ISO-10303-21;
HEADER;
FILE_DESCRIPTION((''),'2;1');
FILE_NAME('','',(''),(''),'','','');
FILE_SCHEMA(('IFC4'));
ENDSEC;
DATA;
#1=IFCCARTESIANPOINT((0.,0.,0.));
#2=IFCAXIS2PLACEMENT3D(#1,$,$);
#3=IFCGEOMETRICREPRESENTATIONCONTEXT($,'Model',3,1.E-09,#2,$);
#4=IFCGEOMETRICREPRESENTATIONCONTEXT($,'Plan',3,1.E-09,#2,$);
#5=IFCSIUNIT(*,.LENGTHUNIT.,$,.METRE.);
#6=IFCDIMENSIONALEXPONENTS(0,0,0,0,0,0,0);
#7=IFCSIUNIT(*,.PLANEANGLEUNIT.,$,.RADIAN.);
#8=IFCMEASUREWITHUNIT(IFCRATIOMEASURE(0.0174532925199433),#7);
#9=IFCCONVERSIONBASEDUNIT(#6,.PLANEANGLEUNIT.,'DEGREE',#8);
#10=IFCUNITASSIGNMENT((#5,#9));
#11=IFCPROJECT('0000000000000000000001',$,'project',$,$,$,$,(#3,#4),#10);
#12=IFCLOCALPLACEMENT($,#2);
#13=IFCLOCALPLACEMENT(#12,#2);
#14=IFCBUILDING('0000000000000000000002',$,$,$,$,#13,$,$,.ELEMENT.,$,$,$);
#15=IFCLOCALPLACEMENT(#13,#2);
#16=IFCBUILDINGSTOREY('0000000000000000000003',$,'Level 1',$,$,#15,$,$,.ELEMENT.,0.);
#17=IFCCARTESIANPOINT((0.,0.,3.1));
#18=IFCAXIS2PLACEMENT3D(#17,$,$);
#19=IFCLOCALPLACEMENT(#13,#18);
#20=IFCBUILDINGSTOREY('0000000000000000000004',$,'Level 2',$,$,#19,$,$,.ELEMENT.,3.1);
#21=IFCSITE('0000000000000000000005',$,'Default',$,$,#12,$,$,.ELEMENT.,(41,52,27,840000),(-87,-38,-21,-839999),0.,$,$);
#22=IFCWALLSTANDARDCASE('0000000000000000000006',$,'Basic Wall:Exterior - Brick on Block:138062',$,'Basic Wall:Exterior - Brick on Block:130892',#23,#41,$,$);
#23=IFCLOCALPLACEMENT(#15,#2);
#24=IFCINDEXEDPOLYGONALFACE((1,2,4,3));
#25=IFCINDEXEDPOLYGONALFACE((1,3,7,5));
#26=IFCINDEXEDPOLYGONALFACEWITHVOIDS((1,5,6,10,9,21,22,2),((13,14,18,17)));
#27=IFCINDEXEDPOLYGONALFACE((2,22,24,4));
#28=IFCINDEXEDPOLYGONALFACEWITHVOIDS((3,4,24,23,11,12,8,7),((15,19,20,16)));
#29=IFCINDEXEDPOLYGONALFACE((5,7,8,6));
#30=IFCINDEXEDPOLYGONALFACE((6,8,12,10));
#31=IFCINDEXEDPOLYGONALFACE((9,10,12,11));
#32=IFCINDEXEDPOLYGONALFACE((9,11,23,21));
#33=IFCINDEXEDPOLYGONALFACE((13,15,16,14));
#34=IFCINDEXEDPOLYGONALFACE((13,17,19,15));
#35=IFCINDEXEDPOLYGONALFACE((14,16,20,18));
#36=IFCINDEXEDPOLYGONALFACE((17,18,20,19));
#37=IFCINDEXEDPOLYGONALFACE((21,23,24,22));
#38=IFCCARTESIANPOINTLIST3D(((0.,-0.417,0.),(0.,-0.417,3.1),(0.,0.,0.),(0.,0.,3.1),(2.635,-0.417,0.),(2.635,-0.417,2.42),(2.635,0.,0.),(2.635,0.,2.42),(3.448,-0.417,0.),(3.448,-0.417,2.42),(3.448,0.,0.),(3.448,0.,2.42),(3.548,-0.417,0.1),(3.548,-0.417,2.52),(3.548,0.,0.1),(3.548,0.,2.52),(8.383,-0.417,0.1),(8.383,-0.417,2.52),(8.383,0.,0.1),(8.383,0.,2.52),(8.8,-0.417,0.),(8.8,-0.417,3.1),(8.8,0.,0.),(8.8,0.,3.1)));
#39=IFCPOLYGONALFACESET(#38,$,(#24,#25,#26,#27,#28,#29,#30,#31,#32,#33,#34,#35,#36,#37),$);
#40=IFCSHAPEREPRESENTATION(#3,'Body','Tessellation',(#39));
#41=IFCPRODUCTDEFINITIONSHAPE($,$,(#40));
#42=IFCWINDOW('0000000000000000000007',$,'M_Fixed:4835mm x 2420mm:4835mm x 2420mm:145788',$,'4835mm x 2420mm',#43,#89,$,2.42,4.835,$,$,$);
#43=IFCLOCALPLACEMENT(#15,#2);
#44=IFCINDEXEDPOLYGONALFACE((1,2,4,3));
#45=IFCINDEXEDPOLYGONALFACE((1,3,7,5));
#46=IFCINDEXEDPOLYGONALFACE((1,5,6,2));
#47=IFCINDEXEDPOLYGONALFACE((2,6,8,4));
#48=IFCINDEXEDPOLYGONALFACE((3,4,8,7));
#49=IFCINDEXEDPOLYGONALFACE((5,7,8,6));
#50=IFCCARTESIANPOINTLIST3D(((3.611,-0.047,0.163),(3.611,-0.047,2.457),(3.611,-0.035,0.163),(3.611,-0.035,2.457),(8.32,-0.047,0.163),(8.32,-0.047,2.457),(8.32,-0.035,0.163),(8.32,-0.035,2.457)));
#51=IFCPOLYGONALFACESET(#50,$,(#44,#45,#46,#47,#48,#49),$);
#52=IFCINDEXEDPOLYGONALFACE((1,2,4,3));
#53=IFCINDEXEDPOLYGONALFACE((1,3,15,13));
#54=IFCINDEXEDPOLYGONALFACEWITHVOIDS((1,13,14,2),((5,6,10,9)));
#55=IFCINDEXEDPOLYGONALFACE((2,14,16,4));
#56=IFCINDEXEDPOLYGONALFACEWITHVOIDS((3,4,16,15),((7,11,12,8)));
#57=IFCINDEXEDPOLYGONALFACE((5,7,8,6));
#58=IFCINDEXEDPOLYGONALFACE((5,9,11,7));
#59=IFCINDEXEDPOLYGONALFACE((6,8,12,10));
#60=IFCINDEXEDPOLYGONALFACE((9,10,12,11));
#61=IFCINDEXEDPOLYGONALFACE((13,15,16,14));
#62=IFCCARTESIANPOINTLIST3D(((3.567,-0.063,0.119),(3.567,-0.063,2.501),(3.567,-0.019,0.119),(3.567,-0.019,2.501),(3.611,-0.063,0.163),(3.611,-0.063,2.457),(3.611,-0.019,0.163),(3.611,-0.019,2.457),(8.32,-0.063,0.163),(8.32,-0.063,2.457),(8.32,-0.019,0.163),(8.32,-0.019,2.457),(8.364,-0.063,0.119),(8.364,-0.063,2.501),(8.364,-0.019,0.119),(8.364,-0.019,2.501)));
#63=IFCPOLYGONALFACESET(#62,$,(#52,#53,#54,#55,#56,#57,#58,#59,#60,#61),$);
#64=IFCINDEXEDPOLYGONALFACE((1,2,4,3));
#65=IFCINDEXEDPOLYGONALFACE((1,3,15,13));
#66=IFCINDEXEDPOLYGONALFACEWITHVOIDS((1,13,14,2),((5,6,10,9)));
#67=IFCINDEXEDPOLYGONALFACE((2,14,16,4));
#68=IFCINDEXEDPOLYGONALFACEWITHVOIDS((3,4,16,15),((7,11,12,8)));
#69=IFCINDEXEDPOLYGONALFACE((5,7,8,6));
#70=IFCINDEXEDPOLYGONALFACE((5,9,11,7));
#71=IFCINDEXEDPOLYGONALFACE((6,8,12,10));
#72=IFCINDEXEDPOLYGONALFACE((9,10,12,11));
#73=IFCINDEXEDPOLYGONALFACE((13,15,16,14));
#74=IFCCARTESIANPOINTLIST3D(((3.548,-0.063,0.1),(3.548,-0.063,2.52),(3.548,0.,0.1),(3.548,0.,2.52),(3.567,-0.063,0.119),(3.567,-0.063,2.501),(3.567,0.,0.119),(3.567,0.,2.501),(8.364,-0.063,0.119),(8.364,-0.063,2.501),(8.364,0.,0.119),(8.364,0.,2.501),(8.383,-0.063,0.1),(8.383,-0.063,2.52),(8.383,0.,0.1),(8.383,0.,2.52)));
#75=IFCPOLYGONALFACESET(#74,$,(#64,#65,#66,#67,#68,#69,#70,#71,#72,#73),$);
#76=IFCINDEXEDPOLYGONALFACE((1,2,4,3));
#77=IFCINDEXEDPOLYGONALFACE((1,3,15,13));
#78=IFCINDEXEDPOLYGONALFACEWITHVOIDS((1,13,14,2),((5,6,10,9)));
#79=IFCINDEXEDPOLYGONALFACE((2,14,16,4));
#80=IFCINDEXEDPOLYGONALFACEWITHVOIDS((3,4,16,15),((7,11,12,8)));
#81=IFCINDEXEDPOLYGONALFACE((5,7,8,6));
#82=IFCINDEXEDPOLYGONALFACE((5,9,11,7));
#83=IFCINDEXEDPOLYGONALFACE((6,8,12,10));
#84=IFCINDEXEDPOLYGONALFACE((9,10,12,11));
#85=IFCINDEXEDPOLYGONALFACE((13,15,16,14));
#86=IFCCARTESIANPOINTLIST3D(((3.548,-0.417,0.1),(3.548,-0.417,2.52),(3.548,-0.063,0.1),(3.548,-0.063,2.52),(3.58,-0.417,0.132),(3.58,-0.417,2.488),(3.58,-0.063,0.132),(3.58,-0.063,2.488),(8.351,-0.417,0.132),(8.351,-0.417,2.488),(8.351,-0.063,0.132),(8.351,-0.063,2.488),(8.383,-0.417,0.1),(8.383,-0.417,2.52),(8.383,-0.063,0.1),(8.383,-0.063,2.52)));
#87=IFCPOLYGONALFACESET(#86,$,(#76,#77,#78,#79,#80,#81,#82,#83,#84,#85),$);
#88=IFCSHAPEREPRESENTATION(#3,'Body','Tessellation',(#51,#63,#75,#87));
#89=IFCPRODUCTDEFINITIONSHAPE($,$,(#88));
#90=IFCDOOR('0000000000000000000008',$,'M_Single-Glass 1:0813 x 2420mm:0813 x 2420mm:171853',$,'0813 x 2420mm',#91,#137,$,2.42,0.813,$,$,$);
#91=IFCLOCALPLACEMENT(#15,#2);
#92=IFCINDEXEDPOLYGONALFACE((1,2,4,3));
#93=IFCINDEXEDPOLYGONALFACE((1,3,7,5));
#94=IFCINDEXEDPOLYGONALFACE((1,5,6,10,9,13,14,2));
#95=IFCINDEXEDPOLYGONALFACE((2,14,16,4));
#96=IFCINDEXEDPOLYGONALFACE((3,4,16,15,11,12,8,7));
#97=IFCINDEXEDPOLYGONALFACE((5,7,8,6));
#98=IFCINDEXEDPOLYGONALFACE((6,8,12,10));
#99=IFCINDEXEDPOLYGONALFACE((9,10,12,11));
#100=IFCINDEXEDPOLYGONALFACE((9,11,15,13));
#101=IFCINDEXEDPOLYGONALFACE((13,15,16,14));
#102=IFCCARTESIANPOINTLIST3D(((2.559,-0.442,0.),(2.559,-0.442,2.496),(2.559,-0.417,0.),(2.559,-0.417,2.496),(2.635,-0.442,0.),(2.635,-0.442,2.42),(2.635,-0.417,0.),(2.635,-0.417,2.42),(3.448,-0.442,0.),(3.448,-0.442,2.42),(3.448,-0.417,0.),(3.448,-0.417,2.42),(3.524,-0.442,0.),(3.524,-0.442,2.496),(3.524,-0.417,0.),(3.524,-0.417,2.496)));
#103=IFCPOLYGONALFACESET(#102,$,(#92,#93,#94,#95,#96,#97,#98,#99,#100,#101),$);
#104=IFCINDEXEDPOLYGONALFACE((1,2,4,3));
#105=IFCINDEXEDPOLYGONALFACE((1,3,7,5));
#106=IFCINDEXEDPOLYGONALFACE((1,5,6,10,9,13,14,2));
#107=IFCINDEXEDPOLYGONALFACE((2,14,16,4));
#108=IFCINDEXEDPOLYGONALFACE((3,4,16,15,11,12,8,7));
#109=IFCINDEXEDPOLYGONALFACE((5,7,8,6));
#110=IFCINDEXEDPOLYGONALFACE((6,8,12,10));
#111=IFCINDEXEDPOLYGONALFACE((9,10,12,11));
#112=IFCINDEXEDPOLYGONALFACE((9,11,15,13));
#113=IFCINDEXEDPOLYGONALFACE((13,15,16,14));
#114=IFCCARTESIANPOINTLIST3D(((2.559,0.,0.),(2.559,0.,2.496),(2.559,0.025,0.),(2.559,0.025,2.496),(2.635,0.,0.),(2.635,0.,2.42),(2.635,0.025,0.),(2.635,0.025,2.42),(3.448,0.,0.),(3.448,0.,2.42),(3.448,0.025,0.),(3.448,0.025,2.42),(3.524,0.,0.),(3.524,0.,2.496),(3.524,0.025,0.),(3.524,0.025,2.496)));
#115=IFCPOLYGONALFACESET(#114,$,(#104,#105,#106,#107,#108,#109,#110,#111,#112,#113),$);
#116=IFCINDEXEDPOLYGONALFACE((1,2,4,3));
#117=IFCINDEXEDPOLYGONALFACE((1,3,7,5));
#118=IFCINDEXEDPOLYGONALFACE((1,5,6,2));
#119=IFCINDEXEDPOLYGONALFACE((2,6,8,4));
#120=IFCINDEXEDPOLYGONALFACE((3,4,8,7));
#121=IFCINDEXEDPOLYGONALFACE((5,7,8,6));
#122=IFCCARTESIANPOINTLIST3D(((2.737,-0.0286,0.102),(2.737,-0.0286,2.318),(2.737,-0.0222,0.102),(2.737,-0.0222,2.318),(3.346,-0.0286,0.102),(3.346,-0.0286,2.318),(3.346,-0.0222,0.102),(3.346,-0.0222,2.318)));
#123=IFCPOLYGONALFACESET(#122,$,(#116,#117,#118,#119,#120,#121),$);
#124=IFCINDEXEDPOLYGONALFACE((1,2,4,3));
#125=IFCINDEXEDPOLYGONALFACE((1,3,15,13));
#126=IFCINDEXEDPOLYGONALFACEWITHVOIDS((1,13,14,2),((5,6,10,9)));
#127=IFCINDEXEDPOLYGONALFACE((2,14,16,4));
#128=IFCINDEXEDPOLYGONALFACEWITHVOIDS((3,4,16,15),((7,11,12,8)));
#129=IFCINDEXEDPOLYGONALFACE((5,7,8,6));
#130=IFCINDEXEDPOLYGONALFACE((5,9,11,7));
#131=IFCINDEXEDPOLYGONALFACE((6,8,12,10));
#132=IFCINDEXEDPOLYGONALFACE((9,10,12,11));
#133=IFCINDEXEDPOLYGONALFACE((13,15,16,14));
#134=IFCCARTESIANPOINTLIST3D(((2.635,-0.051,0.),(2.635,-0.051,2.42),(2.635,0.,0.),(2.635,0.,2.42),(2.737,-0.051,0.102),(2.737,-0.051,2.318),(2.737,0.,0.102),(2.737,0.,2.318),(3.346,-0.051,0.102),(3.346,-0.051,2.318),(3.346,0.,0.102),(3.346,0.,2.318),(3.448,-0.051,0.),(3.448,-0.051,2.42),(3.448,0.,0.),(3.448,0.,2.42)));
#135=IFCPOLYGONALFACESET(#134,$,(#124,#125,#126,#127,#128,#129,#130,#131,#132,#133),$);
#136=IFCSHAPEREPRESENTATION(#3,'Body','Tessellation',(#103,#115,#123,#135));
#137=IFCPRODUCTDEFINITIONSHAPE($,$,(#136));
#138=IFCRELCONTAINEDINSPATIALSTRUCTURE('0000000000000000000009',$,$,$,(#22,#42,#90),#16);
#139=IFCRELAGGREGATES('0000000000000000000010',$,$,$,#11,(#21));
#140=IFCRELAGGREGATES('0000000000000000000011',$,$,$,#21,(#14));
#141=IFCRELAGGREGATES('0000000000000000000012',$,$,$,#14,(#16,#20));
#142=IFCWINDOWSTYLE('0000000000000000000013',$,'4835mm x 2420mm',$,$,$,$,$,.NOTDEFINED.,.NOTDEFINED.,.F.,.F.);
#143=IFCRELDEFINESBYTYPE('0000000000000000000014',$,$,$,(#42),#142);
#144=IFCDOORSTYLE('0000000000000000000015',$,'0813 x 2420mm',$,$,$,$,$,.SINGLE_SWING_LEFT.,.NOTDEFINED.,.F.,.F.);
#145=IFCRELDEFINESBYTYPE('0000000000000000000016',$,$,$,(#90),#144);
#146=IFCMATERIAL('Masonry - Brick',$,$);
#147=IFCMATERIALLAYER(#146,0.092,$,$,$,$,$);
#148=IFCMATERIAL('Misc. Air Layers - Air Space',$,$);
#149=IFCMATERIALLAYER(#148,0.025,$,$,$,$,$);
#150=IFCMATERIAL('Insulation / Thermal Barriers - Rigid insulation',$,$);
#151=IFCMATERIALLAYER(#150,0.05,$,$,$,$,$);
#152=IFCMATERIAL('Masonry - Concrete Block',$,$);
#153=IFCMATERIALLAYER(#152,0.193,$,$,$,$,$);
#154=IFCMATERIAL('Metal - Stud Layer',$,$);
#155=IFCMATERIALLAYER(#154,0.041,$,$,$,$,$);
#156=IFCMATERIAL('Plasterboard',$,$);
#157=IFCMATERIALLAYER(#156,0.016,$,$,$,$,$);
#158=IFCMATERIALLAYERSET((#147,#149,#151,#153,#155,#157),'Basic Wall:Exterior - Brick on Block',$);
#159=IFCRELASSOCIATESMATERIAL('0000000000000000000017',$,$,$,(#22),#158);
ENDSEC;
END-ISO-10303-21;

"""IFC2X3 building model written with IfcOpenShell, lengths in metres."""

from ifc_helpers import new_model, entity, si_unit, converted_unit, frame, frame_2d, origin, origin_2d_with_axis, place, context, project, spatial, polyline, rectangle, outline, extrude, source, transform, mapped, material, layer, layer_set, layer_usage, type_object, type_shapes, element, fill, save


model = new_model("IFC2X3")

# Units and contexts
model_context = context("Model", 3, precision=1e-09, world=origin())
plan_context = context("Plan", 3, precision=1e-09, world=origin())
ifc_project = project(units=[si_unit("LENGTHUNIT", "METRE"), converted_unit("PLANEANGLEUNIT", "DEGREE", entity("IfcRatioMeasure", 0.0174532925199433), si_unit("PLANEANGLEUNIT", "RADIAN"), dimensions=[0, 0, 0, 0, 0, 0, 0])], contexts=[model_context, plan_context])

# Site, building, storey
site_placement = place(None, origin())
site = spatial("IfcSite", under=ifc_project, at=site_placement, Name="Default", CompositionType="ELEMENT", RefLatitude=(41, 52, 27, 840000), RefLongitude=(-87, -38, -21, -839999), RefElevation=0.0)
building_placement = place(site_placement, origin())
building = spatial("IfcBuilding", under=site, at=building_placement, CompositionType="ELEMENT")
storey_1_placement = place(building_placement, origin())
storey_1 = spatial("IfcBuildingStorey", under=building, at=storey_1_placement, Name="Level 1", CompositionType="ELEMENT", Elevation=0.0)

# Wall, openings, window, door
ifc_material_1 = material(Name="Masonry - Brick")
ifc_layer_1 = layer(ifc_material_1, 0.092)
ifc_material_2 = material(Name="Misc. Air Layers - Air Space")
ifc_layer_2 = layer(ifc_material_2, 0.025)
ifc_material_3 = material(Name="Insulation / Thermal Barriers - Rigid insulation")
ifc_layer_3 = layer(ifc_material_3, 0.05)
ifc_material_4 = material(Name="Masonry - Concrete Block")
ifc_layer_4 = layer(ifc_material_4, 0.193)
ifc_material_5 = material(Name="Metal - Stud Layer")
ifc_layer_5 = layer(ifc_material_5, 0.041)
ifc_material_6 = material(Name="Plasterboard")
ifc_layer_6 = layer(ifc_material_6, 0.016)
ifc_layer_set_1 = layer_set([ifc_layer_1, ifc_layer_2, ifc_layer_3, ifc_layer_4, ifc_layer_5, ifc_layer_6], Name="Basic Wall:Exterior - Brick on Block")
ifc_layer_usage_1 = layer_usage(ifc_layer_set_1, "AXIS2", "NEGATIVE", 0.2085)
wall_1_placement = place(storey_1_placement, frame((0.0, -0.2085, 0.0)))
wall_1 = element("IfcWallStandardCase", 1, at=wall_1_placement, inside=storey_1, material=ifc_layer_usage_1, Name="Basic Wall:Exterior - Brick on Block:138062", ObjectType="Basic Wall:Exterior - Brick on Block:130892", context=model_context, shape_type="SweptSolid", body=[
    extrude(rectangle(XDim=8.8, YDim=0.417, at=frame_2d((4.4, 0.0), x_axis=(-1.0, 0.0))), origin(), (0.0, 0.0, 1.0), 3.1),
])
opening_1_placement = place(wall_1_placement, frame((3.548, -0.2085, 0.1)))
opening_1 = element("IfcOpeningElement", 2, at=opening_1_placement, cuts=wall_1, ObjectType="Opening", context=model_context, shape_type="SweptSolid", body=[
    extrude(rectangle(XDim=2.42, YDim=4.835, at=frame_2d((1.21, 2.4175), x_axis=(1.0, 0.0))), frame((0.0, 0.0, 0.0), z_axis=(0.0, 1.0, 0.0), x_axis=(0.0, 0.0, 1.0)), (0.0, 0.0, 1.0), 0.417),
])
opening_2_placement = place(wall_1_placement, frame((2.635, -0.2085, 0.0)))
opening_2 = element("IfcOpeningElement", 3, at=opening_2_placement, cuts=wall_1, ObjectType="Opening", context=model_context, shape_type="SweptSolid", body=[
    extrude(rectangle(XDim=0.813, YDim=2.42, at=frame_2d((1.21, 0.4065), x_axis=(0.0, -1.0))), frame((0.0, 0.0, 0.0), z_axis=(0.0, 1.0, 0.0), x_axis=(0.0, 0.0, 1.0)), (0.0, 0.0, 1.0), 0.417),
])
window_style_1 = type_object("IfcWindowStyle", Name="4835mm x 2420mm", ConstructionType="NOTDEFINED", OperationType="NOTDEFINED", ParameterTakesPrecedence=False, Sizeable=False)
shared_shape_1 = source(origin(), model_context, "Body", "SweptSolid", [
    extrude(rectangle(XDim=0.012, YDim=4.709, at=origin_2d_with_axis()), frame((2.4175, 0.376, 0.063), z_axis=(0.0, 0.0, 1.0), x_axis=(0.0, -1.0, 0.0)), (0.0, 0.0, 1.0), 2.294),
    extrude(outline(polyline([(-2.3985, -1.191), (2.3985, -1.191), (2.3985, 1.191), (-2.3985, 1.191), (-2.3985, -1.191)]), holes=[polyline([(-2.3545, -1.147), (-2.3545, 1.147), (2.3545, 1.147), (2.3545, -1.147), (-2.3545, -1.147)])]), frame((2.4175, 0.354, 1.21), z_axis=(0.0, 1.0, 0.0), x_axis=(1.0, 0.0, 0.0)), (0.0, 0.0, 1.0), 0.044),
    extrude(outline(polyline([(-2.4175, -1.21), (2.4175, -1.21), (2.4175, 1.21), (-2.4175, 1.21), (-2.4175, -1.21)]), holes=[polyline([(-2.3985, -1.191), (-2.3985, 1.191), (2.3985, 1.191), (2.3985, -1.191), (-2.3985, -1.191)])]), frame((2.4175, 0.354, 1.21), z_axis=(0.0, 1.0, 0.0), x_axis=(1.0, 0.0, 0.0)), (0.0, 0.0, 1.0), 0.063),
    extrude(outline(polyline([(-2.4175, -1.21), (2.4175, -1.21), (2.4175, 1.21), (-2.4175, 1.21), (-2.4175, -1.21)]), holes=[polyline([(-2.3855, -1.178), (-2.3855, 1.178), (2.3855, 1.178), (2.3855, -1.178), (-2.3855, -1.178)])]), frame((2.4175, 0.0, 1.21), z_axis=(0.0, 1.0, 0.0), x_axis=(1.0, 0.0, 0.0)), (0.0, 0.0, 1.0), 0.354),
])
type_shapes(window_style_1, [shared_shape_1])
window_1_placement = place(opening_1_placement, origin())
window_1 = element("IfcWindow", 4, at=window_1_placement, inside=storey_1, type_object=window_style_1, Name="M_Fixed:4835mm x 2420mm:4835mm x 2420mm:145788", ObjectType="4835mm x 2420mm", OverallHeight=2.42, OverallWidth=4.835, context=model_context, shape_type="MappedRepresentation", body=[
    mapped(shared_shape_1, transform((0.0, 0.0, 0.0), scale=1.0)),
])
fill(opening_1, window_1)
door_style_1 = type_object("IfcDoorStyle", Name="0813 x 2420mm", ConstructionType="NOTDEFINED", OperationType="SINGLE_SWING_LEFT", ParameterTakesPrecedence=False, Sizeable=False)
shared_shape_2 = source(origin(), model_context, "Body", "SweptSolid", [
    extrude(outline(polyline([(-0.4065, -1.191), (-0.4065, 1.229), (-0.4825, 1.229), (-0.4825, -1.267), (0.4825, -1.267), (0.4825, 1.229), (0.4065, 1.229), (0.4065, -1.191), (-0.4065, -1.191)])), frame((0.4065, 0.0, 1.229), z_axis=(0.0, 1.0, 0.0), x_axis=(1.0, 0.0, 0.0)), (0.0, 0.0, -1.0), 0.025),
    extrude(outline(polyline([(-0.4065, -1.191), (-0.4065, 1.229), (-0.4825, 1.229), (-0.4825, -1.267), (0.4825, -1.267), (0.4825, 1.229), (0.4065, 1.229), (0.4065, -1.191), (-0.4065, -1.191)])), frame((0.4065, 0.442, 1.229), z_axis=(0.0, 1.0, 0.0), x_axis=(1.0, 0.0, 0.0)), (0.0, 0.0, -1.0), 0.025),
    extrude(rectangle(XDim=0.609, YDim=0.0064, at=origin_2d_with_axis()), frame((0.4065, 0.3916, 0.102)), (0.0, 0.0, 1.0), 2.216),
    extrude(outline(polyline([(-1.21, -0.4065), (1.21, -0.4065), (1.21, 0.4065), (-1.21, 0.4065), (-1.21, -0.4065)]), holes=[polyline([(-1.108, 0.3045), (1.108, 0.3045), (1.108, -0.3045), (-1.108, -0.3045), (-1.108, 0.3045)])]), frame((0.4065, 0.417, 1.21), z_axis=(0.0, -1.0, 0.0), x_axis=(0.0, 0.0, -1.0)), (0.0, 0.0, 1.0), 0.051),
])
type_shapes(door_style_1, [shared_shape_2])
door_1_placement = place(opening_2_placement, origin())
door_1 = element("IfcDoor", 5, at=door_1_placement, inside=storey_1, type_object=door_style_1, Name="M_Single-Glass 1:0813 x 2420mm:0813 x 2420mm:171853", ObjectType="0813 x 2420mm", OverallHeight=2.42, OverallWidth=0.813, context=model_context, shape_type="MappedRepresentation", body=[
    mapped(shared_shape_2, transform((0.0, 0.0, 0.0), scale=1.0)),
])
fill(opening_2, door_1)

# Shared definitions
storey_2_placement = place(building_placement, frame((0.0, 0.0, 3.1)))
storey_2 = spatial("IfcBuildingStorey", under=building, at=storey_2_placement, Name="Level 2", CompositionType="ELEMENT", Elevation=3.1)

save(model, "model.ifc")
